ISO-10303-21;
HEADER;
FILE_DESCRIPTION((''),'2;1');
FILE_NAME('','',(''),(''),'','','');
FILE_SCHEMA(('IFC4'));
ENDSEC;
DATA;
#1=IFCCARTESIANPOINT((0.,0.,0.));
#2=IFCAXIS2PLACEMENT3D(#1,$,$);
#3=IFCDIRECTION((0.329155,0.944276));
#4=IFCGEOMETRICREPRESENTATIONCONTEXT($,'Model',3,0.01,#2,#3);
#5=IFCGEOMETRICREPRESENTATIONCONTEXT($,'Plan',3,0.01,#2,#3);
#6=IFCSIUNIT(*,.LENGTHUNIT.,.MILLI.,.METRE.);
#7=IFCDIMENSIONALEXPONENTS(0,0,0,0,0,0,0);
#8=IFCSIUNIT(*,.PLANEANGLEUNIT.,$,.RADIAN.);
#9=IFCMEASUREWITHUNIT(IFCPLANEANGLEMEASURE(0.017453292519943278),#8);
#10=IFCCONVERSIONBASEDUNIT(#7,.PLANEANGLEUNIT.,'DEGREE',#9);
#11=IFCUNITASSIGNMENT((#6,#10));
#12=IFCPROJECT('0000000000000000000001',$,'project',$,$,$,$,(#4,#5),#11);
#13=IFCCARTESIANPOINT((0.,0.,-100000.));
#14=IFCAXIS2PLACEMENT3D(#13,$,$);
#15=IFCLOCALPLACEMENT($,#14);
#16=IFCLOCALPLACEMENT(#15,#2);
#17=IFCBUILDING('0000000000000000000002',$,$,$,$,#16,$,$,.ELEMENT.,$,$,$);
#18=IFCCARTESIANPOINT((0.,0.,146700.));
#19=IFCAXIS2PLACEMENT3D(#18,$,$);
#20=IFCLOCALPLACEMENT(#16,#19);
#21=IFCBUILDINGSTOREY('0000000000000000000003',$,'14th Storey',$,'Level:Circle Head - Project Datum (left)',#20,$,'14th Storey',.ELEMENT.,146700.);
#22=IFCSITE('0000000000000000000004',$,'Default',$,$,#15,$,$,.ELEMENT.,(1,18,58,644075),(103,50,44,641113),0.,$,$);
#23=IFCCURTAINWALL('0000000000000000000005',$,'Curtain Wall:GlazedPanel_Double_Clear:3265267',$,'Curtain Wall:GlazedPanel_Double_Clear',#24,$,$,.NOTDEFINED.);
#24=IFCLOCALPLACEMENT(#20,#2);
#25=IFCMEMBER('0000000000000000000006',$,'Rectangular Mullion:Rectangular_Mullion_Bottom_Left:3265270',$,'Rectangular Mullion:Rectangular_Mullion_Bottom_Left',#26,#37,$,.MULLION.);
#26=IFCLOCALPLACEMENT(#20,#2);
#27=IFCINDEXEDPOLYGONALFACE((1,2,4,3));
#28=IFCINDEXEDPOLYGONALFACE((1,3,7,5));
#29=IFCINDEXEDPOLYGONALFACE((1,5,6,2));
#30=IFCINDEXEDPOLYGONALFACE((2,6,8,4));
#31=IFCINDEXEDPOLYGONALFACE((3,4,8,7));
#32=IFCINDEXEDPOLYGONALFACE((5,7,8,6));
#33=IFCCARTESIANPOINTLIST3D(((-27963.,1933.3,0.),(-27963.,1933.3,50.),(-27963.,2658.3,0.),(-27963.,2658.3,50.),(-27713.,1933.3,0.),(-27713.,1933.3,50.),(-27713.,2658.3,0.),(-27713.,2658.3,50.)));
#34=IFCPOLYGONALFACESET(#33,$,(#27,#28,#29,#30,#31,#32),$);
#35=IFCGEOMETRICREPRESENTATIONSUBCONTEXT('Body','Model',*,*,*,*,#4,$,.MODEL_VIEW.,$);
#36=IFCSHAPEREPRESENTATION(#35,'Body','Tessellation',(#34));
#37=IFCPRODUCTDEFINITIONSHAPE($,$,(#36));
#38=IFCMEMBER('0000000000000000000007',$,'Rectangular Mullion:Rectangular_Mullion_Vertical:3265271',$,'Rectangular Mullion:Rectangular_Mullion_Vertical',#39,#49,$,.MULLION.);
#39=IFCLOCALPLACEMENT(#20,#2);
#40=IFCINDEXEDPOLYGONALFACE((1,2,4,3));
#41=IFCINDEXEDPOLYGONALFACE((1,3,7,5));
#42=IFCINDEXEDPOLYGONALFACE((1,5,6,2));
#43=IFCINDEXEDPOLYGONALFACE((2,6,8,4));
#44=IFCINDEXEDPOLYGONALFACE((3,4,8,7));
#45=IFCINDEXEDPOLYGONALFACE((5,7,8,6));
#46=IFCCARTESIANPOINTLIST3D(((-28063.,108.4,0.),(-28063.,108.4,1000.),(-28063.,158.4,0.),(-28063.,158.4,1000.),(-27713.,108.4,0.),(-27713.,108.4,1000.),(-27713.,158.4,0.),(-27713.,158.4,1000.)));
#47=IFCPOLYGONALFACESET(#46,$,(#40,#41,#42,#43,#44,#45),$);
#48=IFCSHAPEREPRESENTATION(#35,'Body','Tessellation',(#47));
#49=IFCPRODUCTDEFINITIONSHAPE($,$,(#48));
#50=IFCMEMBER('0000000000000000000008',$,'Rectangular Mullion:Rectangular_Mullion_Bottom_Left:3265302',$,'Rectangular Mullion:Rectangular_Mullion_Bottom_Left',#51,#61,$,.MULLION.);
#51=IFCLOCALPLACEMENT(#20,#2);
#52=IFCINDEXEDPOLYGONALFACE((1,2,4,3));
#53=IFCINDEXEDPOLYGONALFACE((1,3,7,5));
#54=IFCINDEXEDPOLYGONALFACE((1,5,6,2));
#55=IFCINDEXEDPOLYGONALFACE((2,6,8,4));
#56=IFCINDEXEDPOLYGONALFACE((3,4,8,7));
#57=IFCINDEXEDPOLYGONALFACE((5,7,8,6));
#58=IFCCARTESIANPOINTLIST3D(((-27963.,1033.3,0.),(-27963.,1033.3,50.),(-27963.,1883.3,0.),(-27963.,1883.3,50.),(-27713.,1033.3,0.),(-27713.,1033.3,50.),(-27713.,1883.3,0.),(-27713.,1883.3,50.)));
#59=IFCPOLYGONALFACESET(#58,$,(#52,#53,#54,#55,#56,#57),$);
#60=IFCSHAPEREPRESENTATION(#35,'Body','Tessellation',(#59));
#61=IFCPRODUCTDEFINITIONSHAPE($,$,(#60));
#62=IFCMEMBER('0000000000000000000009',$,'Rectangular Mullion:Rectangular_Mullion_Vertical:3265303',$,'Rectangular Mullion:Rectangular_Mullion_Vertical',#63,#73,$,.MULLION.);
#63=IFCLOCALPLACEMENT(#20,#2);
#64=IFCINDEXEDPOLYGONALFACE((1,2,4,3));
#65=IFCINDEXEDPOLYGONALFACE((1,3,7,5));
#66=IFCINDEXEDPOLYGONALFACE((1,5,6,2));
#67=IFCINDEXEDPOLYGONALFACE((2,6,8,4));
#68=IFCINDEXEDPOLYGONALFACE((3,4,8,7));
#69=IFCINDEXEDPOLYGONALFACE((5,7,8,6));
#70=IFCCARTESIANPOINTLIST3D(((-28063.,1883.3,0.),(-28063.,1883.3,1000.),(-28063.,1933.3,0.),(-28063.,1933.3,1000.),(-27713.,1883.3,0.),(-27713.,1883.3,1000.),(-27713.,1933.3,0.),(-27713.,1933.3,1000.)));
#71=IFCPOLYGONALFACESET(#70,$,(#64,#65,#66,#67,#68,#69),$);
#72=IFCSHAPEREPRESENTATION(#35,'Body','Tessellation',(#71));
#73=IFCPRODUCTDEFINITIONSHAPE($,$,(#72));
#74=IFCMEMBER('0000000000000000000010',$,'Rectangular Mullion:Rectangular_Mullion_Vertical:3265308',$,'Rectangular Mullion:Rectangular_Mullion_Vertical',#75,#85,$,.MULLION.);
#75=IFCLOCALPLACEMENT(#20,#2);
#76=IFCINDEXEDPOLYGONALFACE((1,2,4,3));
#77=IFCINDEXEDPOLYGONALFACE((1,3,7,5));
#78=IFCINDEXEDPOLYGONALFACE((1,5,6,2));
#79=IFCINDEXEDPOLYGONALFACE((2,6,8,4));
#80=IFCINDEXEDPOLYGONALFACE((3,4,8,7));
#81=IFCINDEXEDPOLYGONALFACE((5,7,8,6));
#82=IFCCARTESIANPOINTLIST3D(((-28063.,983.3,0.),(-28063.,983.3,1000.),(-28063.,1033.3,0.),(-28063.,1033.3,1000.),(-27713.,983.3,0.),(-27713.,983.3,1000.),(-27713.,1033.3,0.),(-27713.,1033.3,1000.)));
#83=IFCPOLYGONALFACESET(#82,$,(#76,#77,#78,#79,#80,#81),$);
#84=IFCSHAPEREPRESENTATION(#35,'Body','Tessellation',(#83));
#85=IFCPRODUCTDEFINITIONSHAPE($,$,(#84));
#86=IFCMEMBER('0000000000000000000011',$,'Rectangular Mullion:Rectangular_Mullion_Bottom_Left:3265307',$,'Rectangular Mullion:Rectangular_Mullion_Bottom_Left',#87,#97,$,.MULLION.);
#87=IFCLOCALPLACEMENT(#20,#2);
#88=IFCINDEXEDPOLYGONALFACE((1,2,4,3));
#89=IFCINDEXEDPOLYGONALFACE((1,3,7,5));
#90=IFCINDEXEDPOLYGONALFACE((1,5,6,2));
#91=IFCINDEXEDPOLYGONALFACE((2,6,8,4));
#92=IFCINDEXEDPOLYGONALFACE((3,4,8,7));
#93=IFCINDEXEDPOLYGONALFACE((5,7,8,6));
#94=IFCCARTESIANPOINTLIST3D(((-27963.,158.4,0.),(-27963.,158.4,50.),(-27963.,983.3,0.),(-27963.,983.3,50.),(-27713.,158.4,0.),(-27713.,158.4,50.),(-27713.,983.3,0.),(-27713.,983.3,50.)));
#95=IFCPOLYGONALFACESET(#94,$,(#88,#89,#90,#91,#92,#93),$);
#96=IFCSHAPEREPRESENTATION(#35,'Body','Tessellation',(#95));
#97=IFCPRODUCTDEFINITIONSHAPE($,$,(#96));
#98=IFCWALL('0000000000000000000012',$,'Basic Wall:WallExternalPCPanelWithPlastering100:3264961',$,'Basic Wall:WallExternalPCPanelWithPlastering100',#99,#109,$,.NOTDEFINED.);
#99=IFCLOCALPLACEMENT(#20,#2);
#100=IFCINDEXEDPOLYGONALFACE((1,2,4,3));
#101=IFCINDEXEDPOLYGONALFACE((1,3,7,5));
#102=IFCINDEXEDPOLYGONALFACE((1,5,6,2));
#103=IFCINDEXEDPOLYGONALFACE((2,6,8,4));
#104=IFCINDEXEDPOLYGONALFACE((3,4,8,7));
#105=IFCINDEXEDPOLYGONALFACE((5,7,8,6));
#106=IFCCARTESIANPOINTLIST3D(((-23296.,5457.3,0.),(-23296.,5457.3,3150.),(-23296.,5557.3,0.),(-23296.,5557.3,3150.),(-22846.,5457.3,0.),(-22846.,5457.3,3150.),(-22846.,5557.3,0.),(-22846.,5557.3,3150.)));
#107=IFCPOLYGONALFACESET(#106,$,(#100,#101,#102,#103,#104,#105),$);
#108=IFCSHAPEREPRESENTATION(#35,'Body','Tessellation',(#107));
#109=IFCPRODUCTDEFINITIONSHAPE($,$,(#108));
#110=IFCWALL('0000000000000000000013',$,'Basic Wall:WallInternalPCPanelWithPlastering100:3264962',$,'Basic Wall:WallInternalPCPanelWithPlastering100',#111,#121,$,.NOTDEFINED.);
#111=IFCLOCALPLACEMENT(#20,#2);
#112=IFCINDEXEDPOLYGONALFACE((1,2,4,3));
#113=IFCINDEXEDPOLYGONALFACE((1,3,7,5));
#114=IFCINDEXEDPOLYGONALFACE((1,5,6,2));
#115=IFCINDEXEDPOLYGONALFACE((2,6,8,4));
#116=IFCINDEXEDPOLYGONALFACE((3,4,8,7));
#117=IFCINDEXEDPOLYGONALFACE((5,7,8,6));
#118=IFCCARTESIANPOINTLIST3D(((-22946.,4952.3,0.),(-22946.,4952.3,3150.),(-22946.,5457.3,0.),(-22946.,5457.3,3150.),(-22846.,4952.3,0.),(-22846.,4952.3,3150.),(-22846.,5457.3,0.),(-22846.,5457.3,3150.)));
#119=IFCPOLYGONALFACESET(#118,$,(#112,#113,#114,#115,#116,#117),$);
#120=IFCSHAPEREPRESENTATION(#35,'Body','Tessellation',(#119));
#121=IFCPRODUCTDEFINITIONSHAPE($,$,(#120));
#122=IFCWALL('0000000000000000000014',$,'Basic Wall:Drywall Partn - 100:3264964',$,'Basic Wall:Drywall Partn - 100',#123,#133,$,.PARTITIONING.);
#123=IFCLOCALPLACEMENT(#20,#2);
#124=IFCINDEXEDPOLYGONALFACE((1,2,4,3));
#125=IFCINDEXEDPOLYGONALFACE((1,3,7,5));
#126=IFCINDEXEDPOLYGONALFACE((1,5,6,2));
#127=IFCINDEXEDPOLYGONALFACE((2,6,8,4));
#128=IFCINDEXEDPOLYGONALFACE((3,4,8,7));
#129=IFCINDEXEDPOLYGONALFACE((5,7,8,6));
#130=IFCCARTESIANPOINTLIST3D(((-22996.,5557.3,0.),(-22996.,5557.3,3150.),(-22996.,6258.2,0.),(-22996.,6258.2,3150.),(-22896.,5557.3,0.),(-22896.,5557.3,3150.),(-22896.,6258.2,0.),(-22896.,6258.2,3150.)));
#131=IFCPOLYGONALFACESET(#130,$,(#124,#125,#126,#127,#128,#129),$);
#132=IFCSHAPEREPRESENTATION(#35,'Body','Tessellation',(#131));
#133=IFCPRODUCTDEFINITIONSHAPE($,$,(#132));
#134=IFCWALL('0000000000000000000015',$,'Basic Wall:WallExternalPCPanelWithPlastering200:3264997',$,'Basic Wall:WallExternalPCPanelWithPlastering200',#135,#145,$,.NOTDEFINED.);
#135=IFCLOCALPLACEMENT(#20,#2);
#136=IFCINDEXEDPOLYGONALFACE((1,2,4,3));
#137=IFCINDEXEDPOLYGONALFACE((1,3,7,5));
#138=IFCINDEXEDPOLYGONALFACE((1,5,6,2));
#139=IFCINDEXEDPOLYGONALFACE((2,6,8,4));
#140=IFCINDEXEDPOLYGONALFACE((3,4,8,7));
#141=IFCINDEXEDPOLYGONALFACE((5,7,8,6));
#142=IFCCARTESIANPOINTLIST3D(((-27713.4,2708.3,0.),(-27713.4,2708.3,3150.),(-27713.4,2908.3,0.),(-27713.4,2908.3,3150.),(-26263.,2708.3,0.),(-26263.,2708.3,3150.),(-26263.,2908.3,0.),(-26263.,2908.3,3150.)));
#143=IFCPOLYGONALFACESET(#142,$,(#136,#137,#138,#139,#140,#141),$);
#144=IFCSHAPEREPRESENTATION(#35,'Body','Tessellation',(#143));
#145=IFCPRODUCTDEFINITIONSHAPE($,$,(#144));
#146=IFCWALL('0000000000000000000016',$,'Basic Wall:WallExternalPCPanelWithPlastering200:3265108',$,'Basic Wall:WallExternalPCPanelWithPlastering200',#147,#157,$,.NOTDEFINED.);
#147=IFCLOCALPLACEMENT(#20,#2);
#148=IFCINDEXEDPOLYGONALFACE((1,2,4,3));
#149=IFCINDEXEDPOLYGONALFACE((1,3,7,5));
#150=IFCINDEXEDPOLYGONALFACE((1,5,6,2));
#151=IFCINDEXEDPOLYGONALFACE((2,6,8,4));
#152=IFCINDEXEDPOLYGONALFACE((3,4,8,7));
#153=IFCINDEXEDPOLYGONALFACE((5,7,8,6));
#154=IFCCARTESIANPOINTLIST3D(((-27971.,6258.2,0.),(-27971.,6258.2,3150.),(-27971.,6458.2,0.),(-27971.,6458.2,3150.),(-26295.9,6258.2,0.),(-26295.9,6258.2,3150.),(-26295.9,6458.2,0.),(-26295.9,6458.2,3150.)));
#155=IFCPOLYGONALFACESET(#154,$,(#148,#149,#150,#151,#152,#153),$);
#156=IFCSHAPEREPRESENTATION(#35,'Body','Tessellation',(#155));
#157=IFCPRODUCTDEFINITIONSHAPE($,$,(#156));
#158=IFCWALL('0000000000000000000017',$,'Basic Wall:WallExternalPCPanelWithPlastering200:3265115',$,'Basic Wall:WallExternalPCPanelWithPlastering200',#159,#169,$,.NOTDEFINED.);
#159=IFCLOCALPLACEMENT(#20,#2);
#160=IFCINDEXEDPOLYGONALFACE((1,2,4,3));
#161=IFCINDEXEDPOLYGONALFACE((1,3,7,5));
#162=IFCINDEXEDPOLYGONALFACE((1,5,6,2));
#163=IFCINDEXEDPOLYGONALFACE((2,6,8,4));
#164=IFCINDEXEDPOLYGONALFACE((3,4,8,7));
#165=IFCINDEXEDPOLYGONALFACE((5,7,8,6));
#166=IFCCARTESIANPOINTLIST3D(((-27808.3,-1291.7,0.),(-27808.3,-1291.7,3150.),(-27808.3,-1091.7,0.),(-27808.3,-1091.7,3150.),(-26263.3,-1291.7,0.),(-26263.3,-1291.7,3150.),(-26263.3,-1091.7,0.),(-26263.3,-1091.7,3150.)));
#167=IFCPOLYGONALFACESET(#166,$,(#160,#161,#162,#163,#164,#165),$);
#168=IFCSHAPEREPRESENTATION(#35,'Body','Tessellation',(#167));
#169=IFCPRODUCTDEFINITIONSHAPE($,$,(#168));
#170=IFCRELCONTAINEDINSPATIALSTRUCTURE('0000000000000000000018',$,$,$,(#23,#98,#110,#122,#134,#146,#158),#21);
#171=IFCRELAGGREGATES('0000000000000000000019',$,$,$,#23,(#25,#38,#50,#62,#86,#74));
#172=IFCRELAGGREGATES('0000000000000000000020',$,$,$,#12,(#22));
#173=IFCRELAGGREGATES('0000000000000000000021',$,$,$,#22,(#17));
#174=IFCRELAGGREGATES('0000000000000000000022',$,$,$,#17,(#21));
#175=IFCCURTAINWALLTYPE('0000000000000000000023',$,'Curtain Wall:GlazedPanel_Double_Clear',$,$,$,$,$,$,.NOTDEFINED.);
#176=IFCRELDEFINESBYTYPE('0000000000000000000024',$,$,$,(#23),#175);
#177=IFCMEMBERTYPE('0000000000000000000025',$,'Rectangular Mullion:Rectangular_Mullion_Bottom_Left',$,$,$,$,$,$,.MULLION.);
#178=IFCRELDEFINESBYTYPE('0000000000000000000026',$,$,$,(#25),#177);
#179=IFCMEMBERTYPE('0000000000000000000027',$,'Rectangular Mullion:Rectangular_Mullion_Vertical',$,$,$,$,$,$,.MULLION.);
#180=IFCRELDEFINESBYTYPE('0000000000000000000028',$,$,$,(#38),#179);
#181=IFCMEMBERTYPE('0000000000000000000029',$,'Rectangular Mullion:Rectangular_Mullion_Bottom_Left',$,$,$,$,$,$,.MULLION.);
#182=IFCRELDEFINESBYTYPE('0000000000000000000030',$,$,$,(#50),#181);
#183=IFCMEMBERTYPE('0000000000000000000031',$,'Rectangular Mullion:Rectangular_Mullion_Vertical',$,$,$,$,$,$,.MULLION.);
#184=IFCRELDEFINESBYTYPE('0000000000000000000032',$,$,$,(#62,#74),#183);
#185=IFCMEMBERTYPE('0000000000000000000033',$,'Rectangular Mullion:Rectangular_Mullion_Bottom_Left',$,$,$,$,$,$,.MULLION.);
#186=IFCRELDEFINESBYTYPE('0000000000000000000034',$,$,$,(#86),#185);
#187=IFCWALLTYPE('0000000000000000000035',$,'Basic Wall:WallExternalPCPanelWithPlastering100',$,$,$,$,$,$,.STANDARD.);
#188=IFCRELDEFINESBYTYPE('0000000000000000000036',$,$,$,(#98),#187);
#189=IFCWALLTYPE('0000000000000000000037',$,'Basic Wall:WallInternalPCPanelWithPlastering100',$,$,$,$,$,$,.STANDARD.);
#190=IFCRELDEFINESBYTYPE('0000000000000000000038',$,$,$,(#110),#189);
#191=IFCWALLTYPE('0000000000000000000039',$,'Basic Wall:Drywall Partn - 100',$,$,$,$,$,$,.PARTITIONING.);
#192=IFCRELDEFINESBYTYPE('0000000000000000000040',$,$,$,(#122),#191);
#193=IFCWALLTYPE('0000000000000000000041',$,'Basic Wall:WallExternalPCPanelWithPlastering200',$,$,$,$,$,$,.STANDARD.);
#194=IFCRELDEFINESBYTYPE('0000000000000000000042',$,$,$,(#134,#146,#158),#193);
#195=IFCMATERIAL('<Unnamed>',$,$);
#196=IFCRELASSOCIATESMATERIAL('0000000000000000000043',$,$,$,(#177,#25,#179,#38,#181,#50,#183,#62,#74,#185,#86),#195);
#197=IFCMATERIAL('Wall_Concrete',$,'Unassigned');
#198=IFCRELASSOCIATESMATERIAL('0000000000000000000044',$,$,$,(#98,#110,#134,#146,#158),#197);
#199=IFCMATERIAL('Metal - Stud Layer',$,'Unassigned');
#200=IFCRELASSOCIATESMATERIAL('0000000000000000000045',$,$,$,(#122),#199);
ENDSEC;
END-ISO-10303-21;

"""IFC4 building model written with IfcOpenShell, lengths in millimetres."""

from ifc_helpers import new_model, entity, si_unit, converted_unit, direction, frame, origin, place, context, subcontext, project, spatial, indexed_curve, outline, extrude, source, transform, mapped, material, type_object, type_shapes, element, aggregate, save


model = new_model("IFC4")

# Units and contexts
model_context = context("Model", 3, precision=0.01, world=origin(), true_north=direction((0.329155, 0.944276)))
plan_context = context("Plan", 3, precision=0.01, world=origin(), true_north=direction((0.329155, 0.944276)))
body_context = subcontext(model_context, "Body", "Model", "MODEL_VIEW")
ifc_project = project(units=[si_unit("LENGTHUNIT", "METRE", prefix="MILLI"), converted_unit("PLANEANGLEUNIT", "DEGREE", entity("IfcPlaneAngleMeasure", 0.017453292519943278), si_unit("PLANEANGLEUNIT", "RADIAN"), dimensions=[0, 0, 0, 0, 0, 0, 0])], contexts=[model_context, plan_context])

# Site, building, storey
site_placement = place(None, frame((0.0, 0.0, -100000.0)))
site = spatial("IfcSite", under=ifc_project, at=site_placement, Name="Default", CompositionType="ELEMENT", RefLatitude=(1, 18, 58, 644075), RefLongitude=(103, 50, 44, 641113), RefElevation=0.0)
building_placement = place(site_placement, origin())
building = spatial("IfcBuilding", under=site, at=building_placement, CompositionType="ELEMENT")
storey_placement = place(building_placement, frame((0.0, 0.0, 146700.0)))
storey = spatial("IfcBuildingStorey", under=building, at=storey_placement, Name="14th Storey", ObjectType="Level:Circle Head - Project Datum (left)", LongName="14th Storey", CompositionType="ELEMENT", Elevation=146700.0)

# Curtain wall, members
curtain_wall_type = type_object("IfcCurtainWallType", Name="Curtain Wall:GlazedPanel_Double_Clear", PredefinedType="NOTDEFINED")
curtain_wall_placement = place(storey_placement, frame((0.0, 0.0, -146700.0)))
curtain_wall = element("IfcCurtainWall", 1, at=curtain_wall_placement, inside=storey, type_object=curtain_wall_type, Name="Curtain Wall:GlazedPanel_Double_Clear:3265267", ObjectType="Curtain Wall:GlazedPanel_Double_Clear", PredefinedType="NOTDEFINED")
ifc_material_1 = material(Name="<Unnamed>")
member_type_1 = type_object("IfcMemberType", Name="Rectangular Mullion:Rectangular_Mullion_Bottom_Left", PredefinedType="MULLION", material=ifc_material_1)
shared_shape_1 = source(origin(), body_context, "Body", "SweptSolid", [
    extrude(outline(indexed_curve([(-25.0, -125.0), (25.0, -125.0), (25.0, 125.0), (-25.0, 125.0), (-25.0, -125.0)], self_intersect=False)), frame((-25.0, 0.0, -725.0), z_axis=(0.0, 0.0, 1.0), x_axis=(-1.0, 0.0, 0.0)), (0.0, 0.0, 1.0), 725.0),
])
type_shapes(member_type_1, [shared_shape_1])
member_1_placement = place(curtain_wall_placement, frame((-27838.0, 2658.3, 146700.0), z_axis=(0.0, 1.0, 0.0), x_axis=(0.0, 0.0, -1.0)))
member_1 = element("IfcMember", 2, at=member_1_placement, type_object=member_type_1, material=ifc_material_1, Name="Rectangular Mullion:Rectangular_Mullion_Bottom_Left:3265270", ObjectType="Rectangular Mullion:Rectangular_Mullion_Bottom_Left", PredefinedType="MULLION", context=body_context, shape_type="MappedRepresentation", body=[
    mapped(shared_shape_1, transform((0.0, 0.0, 0.0), scale=1.0)),
])
member_type_2 = type_object("IfcMemberType", Name="Rectangular Mullion:Rectangular_Mullion_Vertical", PredefinedType="MULLION", material=ifc_material_1)
shared_shape_2 = source(origin(), body_context, "Body", "SweptSolid", [
    extrude(outline(indexed_curve([(-25.0, -175.0), (25.0, -175.0), (25.0, 175.0), (-25.0, 175.0), (-25.0, -175.0)], self_intersect=False)), frame((-25.0, 50.0, -1000.0), z_axis=(0.0, 0.0, 1.0), x_axis=(-1.0, 0.0, 0.0)), (0.0, 0.0, 1.0), 1000.0),
])
type_shapes(member_type_2, [shared_shape_2])
member_2_placement = place(curtain_wall_placement, frame((-27838.0, 108.4, 146700.0), z_axis=(0.0, 0.0, -1.0), x_axis=(0.0, -1.0, 0.0)))
member_2 = element("IfcMember", 3, at=member_2_placement, type_object=member_type_2, material=ifc_material_1, Name="Rectangular Mullion:Rectangular_Mullion_Vertical:3265271", ObjectType="Rectangular Mullion:Rectangular_Mullion_Vertical", PredefinedType="MULLION", context=body_context, shape_type="MappedRepresentation", body=[
    mapped(shared_shape_2, transform((0.0, 0.0, 0.0), scale=1.0)),
])
member_type_3 = type_object("IfcMemberType", Name="Rectangular Mullion:Rectangular_Mullion_Bottom_Left", PredefinedType="MULLION", material=ifc_material_1)
shared_shape_3 = source(origin(), body_context, "Body", "SweptSolid", [
    extrude(outline(indexed_curve([(-25.0, -125.0), (25.0, -125.0), (25.0, 125.0), (-25.0, 125.0), (-25.0, -125.0)], self_intersect=False)), frame((-25.0, 0.0, -849.9), z_axis=(0.0, 0.0, 1.0), x_axis=(-1.0, 0.0, 0.0)), (0.0, 0.0, 1.0), 849.9),
])
type_shapes(member_type_3, [shared_shape_3])
member_3_placement = place(curtain_wall_placement, frame((-27838.0, 1883.3, 146700.0), z_axis=(0.0, 1.0, 0.0), x_axis=(0.0, 0.0, -1.0)))
member_3 = element("IfcMember", 4, at=member_3_placement, type_object=member_type_3, material=ifc_material_1, Name="Rectangular Mullion:Rectangular_Mullion_Bottom_Left:3265302", ObjectType="Rectangular Mullion:Rectangular_Mullion_Bottom_Left", PredefinedType="MULLION", context=body_context, shape_type="MappedRepresentation", body=[
    mapped(shared_shape_3, transform((0.0, 0.0, 0.0), scale=1.0)),
])
member_type_4 = type_object("IfcMemberType", Name="Rectangular Mullion:Rectangular_Mullion_Vertical", PredefinedType="MULLION", material=ifc_material_1)
shared_shape_4 = source(origin(), body_context, "Body", "SweptSolid", [
    extrude(outline(indexed_curve([(-25.0, -175.0), (25.0, -175.0), (25.0, 175.0), (-25.0, 175.0), (-25.0, -175.0)], self_intersect=False)), frame((0.0, 50.0, -1000.0), z_axis=(0.0, 0.0, 1.0), x_axis=(-1.0, 0.0, 0.0)), (0.0, 0.0, 1.0), 1000.0),
])
type_shapes(member_type_4, [shared_shape_4])
member_4_placement = place(curtain_wall_placement, frame((-27838.0, 1908.3, 146700.0), z_axis=(0.0, 0.0, -1.0), x_axis=(0.0, -1.0, 0.0)))
member_4 = element("IfcMember", 5, at=member_4_placement, type_object=member_type_4, material=ifc_material_1, Name="Rectangular Mullion:Rectangular_Mullion_Vertical:3265303", ObjectType="Rectangular Mullion:Rectangular_Mullion_Vertical", PredefinedType="MULLION", context=body_context, shape_type="MappedRepresentation", body=[
    mapped(shared_shape_4, transform((0.0, 0.0, 0.0), scale=1.0)),
])
member_5_placement = place(curtain_wall_placement, frame((-27838.0, 1008.3, 146700.0), z_axis=(0.0, 0.0, -1.0), x_axis=(0.0, -1.0, 0.0)))
member_5 = element("IfcMember", 6, at=member_5_placement, type_object=member_type_4, material=ifc_material_1, Name="Rectangular Mullion:Rectangular_Mullion_Vertical:3265308", ObjectType="Rectangular Mullion:Rectangular_Mullion_Vertical", PredefinedType="MULLION", context=body_context, shape_type="MappedRepresentation", body=[
    mapped(shared_shape_4, transform((0.0, 0.0, 0.0), scale=1.0)),
])
member_type_5 = type_object("IfcMemberType", Name="Rectangular Mullion:Rectangular_Mullion_Bottom_Left", PredefinedType="MULLION", material=ifc_material_1)
shared_shape_5 = source(origin(), body_context, "Body", "SweptSolid", [
    extrude(outline(indexed_curve([(-25.0, -125.0), (25.0, -125.0), (25.0, 125.0), (-25.0, 125.0), (-25.0, -125.0)], self_intersect=False)), frame((-25.0, 0.0, -825.0), z_axis=(0.0, 0.0, 1.0), x_axis=(-1.0, 0.0, 0.0)), (0.0, 0.0, 1.0), 825.0),
])
type_shapes(member_type_5, [shared_shape_5])
member_6_placement = place(curtain_wall_placement, frame((-27838.0, 983.3, 146700.0), z_axis=(0.0, 1.0, 0.0), x_axis=(0.0, 0.0, -1.0)))
member_6 = element("IfcMember", 7, at=member_6_placement, type_object=member_type_5, material=ifc_material_1, Name="Rectangular Mullion:Rectangular_Mullion_Bottom_Left:3265307", ObjectType="Rectangular Mullion:Rectangular_Mullion_Bottom_Left", PredefinedType="MULLION", context=body_context, shape_type="MappedRepresentation", body=[
    mapped(shared_shape_5, transform((0.0, 0.0, 0.0), scale=1.0)),
])
aggregate(curtain_wall, [member_1, member_2, member_3, member_4, member_6, member_5])

# Walls
ifc_material_2 = material(Name="Wall_Concrete", Category="Unassigned")
wall_type_1 = type_object("IfcWallType", Name="Basic Wall:WallExternalPCPanelWithPlastering100", PredefinedType="STANDARD")
wall_1_placement = place(storey_placement, frame((-23296.0, 5507.3, 0.0)))
element("IfcWall", 8, at=wall_1_placement, inside=storey, type_object=wall_type_1, material=ifc_material_2, Name="Basic Wall:WallExternalPCPanelWithPlastering100:3264961", ObjectType="Basic Wall:WallExternalPCPanelWithPlastering100", PredefinedType="NOTDEFINED", context=body_context, shape_type="SweptSolid", body=[
    extrude(outline(indexed_curve([(450.0, 50.0), (0.0, 50.0), (0.0, -50.0), (450.0, -50.0), (450.0, 50.0)], self_intersect=False)), origin(), (0.0, 0.0, 1.0), 3150.0),
])
wall_type_2 = type_object("IfcWallType", Name="Basic Wall:WallInternalPCPanelWithPlastering100", PredefinedType="STANDARD")
wall_2_placement = place(storey_placement, frame((-22896.0, 5457.3, 0.0), z_axis=(0.0, 0.0, 1.0), x_axis=(0.0, -1.0, 0.0)))
element("IfcWall", 9, at=wall_2_placement, inside=storey, type_object=wall_type_2, material=ifc_material_2, Name="Basic Wall:WallInternalPCPanelWithPlastering100:3264962", ObjectType="Basic Wall:WallInternalPCPanelWithPlastering100", PredefinedType="NOTDEFINED", context=body_context, shape_type="SweptSolid", body=[
    extrude(outline(indexed_curve([(505.0, 50.0), (0.0, 50.0), (0.0, -50.0), (505.0, -50.0), (505.0, 50.0)], self_intersect=False)), origin(), (0.0, 0.0, 1.0), 3150.0),
])
ifc_material_3 = material(Name="Metal - Stud Layer", Category="Unassigned")
wall_type_3 = type_object("IfcWallType", Name="Basic Wall:Drywall Partn - 100", PredefinedType="PARTITIONING")
wall_3_placement = place(storey_placement, frame((-22946.0, 6258.2, 0.0), z_axis=(0.0, 0.0, 1.0), x_axis=(0.0, -1.0, 0.0)))
element("IfcWall", 10, at=wall_3_placement, inside=storey, type_object=wall_type_3, material=ifc_material_3, Name="Basic Wall:Drywall Partn - 100:3264964", ObjectType="Basic Wall:Drywall Partn - 100", PredefinedType="PARTITIONING", context=body_context, shape_type="SweptSolid", body=[
    extrude(outline(indexed_curve([(701.0, 50.0), (0.0, 50.0), (0.0, -50.0), (701.0, -50.0), (701.0, 50.0)], self_intersect=False)), origin(), (0.0, 0.0, 1.0), 3150.0),
])
wall_type_4 = type_object("IfcWallType", Name="Basic Wall:WallExternalPCPanelWithPlastering200", PredefinedType="STANDARD")
wall_4_placement = place(storey_placement, frame((-27713.4, 2808.3, 0.0)))
element("IfcWall", 11, at=wall_4_placement, inside=storey, type_object=wall_type_4, material=ifc_material_2, Name="Basic Wall:WallExternalPCPanelWithPlastering200:3264997", ObjectType="Basic Wall:WallExternalPCPanelWithPlastering200", PredefinedType="NOTDEFINED", context=body_context, shape_type="SweptSolid", body=[
    extrude(outline(indexed_curve([(1450.4, 100.0), (0.0, 100.0), (0.0, -100.0), (1450.4, -100.0), (1450.4, 100.0)], self_intersect=False)), origin(), (0.0, 0.0, 1.0), 3150.0),
])
wall_5_placement = place(storey_placement, frame((-26295.9, 6358.2, 0.0), z_axis=(0.0, 0.0, 1.0), x_axis=(-1.0, 0.0, 0.0)))
element("IfcWall", 12, at=wall_5_placement, inside=storey, type_object=wall_type_4, material=ifc_material_2, Name="Basic Wall:WallExternalPCPanelWithPlastering200:3265108", ObjectType="Basic Wall:WallExternalPCPanelWithPlastering200", PredefinedType="NOTDEFINED", context=body_context, shape_type="SweptSolid", body=[
    extrude(outline(indexed_curve([(1675.1, 100.0), (0.0, 100.0), (0.0, -100.0), (1675.1, -100.0), (1675.1, 100.0)], self_intersect=False)), origin(), (0.0, 0.0, 1.0), 3150.0),
])
wall_6_placement = place(storey_placement, frame((-27808.3, -1191.7, 0.0)))
element("IfcWall", 13, at=wall_6_placement, inside=storey, type_object=wall_type_4, material=ifc_material_2, Name="Basic Wall:WallExternalPCPanelWithPlastering200:3265115", ObjectType="Basic Wall:WallExternalPCPanelWithPlastering200", PredefinedType="NOTDEFINED", context=body_context, shape_type="SweptSolid", body=[
    extrude(outline(indexed_curve([(1545.0, 100.0), (0.0, 100.0), (0.0, -100.0), (1545.0, -100.0), (1545.0, 100.0)], self_intersect=False)), origin(), (0.0, 0.0, 1.0), 3150.0),
])

save(model, "model.ifc")
